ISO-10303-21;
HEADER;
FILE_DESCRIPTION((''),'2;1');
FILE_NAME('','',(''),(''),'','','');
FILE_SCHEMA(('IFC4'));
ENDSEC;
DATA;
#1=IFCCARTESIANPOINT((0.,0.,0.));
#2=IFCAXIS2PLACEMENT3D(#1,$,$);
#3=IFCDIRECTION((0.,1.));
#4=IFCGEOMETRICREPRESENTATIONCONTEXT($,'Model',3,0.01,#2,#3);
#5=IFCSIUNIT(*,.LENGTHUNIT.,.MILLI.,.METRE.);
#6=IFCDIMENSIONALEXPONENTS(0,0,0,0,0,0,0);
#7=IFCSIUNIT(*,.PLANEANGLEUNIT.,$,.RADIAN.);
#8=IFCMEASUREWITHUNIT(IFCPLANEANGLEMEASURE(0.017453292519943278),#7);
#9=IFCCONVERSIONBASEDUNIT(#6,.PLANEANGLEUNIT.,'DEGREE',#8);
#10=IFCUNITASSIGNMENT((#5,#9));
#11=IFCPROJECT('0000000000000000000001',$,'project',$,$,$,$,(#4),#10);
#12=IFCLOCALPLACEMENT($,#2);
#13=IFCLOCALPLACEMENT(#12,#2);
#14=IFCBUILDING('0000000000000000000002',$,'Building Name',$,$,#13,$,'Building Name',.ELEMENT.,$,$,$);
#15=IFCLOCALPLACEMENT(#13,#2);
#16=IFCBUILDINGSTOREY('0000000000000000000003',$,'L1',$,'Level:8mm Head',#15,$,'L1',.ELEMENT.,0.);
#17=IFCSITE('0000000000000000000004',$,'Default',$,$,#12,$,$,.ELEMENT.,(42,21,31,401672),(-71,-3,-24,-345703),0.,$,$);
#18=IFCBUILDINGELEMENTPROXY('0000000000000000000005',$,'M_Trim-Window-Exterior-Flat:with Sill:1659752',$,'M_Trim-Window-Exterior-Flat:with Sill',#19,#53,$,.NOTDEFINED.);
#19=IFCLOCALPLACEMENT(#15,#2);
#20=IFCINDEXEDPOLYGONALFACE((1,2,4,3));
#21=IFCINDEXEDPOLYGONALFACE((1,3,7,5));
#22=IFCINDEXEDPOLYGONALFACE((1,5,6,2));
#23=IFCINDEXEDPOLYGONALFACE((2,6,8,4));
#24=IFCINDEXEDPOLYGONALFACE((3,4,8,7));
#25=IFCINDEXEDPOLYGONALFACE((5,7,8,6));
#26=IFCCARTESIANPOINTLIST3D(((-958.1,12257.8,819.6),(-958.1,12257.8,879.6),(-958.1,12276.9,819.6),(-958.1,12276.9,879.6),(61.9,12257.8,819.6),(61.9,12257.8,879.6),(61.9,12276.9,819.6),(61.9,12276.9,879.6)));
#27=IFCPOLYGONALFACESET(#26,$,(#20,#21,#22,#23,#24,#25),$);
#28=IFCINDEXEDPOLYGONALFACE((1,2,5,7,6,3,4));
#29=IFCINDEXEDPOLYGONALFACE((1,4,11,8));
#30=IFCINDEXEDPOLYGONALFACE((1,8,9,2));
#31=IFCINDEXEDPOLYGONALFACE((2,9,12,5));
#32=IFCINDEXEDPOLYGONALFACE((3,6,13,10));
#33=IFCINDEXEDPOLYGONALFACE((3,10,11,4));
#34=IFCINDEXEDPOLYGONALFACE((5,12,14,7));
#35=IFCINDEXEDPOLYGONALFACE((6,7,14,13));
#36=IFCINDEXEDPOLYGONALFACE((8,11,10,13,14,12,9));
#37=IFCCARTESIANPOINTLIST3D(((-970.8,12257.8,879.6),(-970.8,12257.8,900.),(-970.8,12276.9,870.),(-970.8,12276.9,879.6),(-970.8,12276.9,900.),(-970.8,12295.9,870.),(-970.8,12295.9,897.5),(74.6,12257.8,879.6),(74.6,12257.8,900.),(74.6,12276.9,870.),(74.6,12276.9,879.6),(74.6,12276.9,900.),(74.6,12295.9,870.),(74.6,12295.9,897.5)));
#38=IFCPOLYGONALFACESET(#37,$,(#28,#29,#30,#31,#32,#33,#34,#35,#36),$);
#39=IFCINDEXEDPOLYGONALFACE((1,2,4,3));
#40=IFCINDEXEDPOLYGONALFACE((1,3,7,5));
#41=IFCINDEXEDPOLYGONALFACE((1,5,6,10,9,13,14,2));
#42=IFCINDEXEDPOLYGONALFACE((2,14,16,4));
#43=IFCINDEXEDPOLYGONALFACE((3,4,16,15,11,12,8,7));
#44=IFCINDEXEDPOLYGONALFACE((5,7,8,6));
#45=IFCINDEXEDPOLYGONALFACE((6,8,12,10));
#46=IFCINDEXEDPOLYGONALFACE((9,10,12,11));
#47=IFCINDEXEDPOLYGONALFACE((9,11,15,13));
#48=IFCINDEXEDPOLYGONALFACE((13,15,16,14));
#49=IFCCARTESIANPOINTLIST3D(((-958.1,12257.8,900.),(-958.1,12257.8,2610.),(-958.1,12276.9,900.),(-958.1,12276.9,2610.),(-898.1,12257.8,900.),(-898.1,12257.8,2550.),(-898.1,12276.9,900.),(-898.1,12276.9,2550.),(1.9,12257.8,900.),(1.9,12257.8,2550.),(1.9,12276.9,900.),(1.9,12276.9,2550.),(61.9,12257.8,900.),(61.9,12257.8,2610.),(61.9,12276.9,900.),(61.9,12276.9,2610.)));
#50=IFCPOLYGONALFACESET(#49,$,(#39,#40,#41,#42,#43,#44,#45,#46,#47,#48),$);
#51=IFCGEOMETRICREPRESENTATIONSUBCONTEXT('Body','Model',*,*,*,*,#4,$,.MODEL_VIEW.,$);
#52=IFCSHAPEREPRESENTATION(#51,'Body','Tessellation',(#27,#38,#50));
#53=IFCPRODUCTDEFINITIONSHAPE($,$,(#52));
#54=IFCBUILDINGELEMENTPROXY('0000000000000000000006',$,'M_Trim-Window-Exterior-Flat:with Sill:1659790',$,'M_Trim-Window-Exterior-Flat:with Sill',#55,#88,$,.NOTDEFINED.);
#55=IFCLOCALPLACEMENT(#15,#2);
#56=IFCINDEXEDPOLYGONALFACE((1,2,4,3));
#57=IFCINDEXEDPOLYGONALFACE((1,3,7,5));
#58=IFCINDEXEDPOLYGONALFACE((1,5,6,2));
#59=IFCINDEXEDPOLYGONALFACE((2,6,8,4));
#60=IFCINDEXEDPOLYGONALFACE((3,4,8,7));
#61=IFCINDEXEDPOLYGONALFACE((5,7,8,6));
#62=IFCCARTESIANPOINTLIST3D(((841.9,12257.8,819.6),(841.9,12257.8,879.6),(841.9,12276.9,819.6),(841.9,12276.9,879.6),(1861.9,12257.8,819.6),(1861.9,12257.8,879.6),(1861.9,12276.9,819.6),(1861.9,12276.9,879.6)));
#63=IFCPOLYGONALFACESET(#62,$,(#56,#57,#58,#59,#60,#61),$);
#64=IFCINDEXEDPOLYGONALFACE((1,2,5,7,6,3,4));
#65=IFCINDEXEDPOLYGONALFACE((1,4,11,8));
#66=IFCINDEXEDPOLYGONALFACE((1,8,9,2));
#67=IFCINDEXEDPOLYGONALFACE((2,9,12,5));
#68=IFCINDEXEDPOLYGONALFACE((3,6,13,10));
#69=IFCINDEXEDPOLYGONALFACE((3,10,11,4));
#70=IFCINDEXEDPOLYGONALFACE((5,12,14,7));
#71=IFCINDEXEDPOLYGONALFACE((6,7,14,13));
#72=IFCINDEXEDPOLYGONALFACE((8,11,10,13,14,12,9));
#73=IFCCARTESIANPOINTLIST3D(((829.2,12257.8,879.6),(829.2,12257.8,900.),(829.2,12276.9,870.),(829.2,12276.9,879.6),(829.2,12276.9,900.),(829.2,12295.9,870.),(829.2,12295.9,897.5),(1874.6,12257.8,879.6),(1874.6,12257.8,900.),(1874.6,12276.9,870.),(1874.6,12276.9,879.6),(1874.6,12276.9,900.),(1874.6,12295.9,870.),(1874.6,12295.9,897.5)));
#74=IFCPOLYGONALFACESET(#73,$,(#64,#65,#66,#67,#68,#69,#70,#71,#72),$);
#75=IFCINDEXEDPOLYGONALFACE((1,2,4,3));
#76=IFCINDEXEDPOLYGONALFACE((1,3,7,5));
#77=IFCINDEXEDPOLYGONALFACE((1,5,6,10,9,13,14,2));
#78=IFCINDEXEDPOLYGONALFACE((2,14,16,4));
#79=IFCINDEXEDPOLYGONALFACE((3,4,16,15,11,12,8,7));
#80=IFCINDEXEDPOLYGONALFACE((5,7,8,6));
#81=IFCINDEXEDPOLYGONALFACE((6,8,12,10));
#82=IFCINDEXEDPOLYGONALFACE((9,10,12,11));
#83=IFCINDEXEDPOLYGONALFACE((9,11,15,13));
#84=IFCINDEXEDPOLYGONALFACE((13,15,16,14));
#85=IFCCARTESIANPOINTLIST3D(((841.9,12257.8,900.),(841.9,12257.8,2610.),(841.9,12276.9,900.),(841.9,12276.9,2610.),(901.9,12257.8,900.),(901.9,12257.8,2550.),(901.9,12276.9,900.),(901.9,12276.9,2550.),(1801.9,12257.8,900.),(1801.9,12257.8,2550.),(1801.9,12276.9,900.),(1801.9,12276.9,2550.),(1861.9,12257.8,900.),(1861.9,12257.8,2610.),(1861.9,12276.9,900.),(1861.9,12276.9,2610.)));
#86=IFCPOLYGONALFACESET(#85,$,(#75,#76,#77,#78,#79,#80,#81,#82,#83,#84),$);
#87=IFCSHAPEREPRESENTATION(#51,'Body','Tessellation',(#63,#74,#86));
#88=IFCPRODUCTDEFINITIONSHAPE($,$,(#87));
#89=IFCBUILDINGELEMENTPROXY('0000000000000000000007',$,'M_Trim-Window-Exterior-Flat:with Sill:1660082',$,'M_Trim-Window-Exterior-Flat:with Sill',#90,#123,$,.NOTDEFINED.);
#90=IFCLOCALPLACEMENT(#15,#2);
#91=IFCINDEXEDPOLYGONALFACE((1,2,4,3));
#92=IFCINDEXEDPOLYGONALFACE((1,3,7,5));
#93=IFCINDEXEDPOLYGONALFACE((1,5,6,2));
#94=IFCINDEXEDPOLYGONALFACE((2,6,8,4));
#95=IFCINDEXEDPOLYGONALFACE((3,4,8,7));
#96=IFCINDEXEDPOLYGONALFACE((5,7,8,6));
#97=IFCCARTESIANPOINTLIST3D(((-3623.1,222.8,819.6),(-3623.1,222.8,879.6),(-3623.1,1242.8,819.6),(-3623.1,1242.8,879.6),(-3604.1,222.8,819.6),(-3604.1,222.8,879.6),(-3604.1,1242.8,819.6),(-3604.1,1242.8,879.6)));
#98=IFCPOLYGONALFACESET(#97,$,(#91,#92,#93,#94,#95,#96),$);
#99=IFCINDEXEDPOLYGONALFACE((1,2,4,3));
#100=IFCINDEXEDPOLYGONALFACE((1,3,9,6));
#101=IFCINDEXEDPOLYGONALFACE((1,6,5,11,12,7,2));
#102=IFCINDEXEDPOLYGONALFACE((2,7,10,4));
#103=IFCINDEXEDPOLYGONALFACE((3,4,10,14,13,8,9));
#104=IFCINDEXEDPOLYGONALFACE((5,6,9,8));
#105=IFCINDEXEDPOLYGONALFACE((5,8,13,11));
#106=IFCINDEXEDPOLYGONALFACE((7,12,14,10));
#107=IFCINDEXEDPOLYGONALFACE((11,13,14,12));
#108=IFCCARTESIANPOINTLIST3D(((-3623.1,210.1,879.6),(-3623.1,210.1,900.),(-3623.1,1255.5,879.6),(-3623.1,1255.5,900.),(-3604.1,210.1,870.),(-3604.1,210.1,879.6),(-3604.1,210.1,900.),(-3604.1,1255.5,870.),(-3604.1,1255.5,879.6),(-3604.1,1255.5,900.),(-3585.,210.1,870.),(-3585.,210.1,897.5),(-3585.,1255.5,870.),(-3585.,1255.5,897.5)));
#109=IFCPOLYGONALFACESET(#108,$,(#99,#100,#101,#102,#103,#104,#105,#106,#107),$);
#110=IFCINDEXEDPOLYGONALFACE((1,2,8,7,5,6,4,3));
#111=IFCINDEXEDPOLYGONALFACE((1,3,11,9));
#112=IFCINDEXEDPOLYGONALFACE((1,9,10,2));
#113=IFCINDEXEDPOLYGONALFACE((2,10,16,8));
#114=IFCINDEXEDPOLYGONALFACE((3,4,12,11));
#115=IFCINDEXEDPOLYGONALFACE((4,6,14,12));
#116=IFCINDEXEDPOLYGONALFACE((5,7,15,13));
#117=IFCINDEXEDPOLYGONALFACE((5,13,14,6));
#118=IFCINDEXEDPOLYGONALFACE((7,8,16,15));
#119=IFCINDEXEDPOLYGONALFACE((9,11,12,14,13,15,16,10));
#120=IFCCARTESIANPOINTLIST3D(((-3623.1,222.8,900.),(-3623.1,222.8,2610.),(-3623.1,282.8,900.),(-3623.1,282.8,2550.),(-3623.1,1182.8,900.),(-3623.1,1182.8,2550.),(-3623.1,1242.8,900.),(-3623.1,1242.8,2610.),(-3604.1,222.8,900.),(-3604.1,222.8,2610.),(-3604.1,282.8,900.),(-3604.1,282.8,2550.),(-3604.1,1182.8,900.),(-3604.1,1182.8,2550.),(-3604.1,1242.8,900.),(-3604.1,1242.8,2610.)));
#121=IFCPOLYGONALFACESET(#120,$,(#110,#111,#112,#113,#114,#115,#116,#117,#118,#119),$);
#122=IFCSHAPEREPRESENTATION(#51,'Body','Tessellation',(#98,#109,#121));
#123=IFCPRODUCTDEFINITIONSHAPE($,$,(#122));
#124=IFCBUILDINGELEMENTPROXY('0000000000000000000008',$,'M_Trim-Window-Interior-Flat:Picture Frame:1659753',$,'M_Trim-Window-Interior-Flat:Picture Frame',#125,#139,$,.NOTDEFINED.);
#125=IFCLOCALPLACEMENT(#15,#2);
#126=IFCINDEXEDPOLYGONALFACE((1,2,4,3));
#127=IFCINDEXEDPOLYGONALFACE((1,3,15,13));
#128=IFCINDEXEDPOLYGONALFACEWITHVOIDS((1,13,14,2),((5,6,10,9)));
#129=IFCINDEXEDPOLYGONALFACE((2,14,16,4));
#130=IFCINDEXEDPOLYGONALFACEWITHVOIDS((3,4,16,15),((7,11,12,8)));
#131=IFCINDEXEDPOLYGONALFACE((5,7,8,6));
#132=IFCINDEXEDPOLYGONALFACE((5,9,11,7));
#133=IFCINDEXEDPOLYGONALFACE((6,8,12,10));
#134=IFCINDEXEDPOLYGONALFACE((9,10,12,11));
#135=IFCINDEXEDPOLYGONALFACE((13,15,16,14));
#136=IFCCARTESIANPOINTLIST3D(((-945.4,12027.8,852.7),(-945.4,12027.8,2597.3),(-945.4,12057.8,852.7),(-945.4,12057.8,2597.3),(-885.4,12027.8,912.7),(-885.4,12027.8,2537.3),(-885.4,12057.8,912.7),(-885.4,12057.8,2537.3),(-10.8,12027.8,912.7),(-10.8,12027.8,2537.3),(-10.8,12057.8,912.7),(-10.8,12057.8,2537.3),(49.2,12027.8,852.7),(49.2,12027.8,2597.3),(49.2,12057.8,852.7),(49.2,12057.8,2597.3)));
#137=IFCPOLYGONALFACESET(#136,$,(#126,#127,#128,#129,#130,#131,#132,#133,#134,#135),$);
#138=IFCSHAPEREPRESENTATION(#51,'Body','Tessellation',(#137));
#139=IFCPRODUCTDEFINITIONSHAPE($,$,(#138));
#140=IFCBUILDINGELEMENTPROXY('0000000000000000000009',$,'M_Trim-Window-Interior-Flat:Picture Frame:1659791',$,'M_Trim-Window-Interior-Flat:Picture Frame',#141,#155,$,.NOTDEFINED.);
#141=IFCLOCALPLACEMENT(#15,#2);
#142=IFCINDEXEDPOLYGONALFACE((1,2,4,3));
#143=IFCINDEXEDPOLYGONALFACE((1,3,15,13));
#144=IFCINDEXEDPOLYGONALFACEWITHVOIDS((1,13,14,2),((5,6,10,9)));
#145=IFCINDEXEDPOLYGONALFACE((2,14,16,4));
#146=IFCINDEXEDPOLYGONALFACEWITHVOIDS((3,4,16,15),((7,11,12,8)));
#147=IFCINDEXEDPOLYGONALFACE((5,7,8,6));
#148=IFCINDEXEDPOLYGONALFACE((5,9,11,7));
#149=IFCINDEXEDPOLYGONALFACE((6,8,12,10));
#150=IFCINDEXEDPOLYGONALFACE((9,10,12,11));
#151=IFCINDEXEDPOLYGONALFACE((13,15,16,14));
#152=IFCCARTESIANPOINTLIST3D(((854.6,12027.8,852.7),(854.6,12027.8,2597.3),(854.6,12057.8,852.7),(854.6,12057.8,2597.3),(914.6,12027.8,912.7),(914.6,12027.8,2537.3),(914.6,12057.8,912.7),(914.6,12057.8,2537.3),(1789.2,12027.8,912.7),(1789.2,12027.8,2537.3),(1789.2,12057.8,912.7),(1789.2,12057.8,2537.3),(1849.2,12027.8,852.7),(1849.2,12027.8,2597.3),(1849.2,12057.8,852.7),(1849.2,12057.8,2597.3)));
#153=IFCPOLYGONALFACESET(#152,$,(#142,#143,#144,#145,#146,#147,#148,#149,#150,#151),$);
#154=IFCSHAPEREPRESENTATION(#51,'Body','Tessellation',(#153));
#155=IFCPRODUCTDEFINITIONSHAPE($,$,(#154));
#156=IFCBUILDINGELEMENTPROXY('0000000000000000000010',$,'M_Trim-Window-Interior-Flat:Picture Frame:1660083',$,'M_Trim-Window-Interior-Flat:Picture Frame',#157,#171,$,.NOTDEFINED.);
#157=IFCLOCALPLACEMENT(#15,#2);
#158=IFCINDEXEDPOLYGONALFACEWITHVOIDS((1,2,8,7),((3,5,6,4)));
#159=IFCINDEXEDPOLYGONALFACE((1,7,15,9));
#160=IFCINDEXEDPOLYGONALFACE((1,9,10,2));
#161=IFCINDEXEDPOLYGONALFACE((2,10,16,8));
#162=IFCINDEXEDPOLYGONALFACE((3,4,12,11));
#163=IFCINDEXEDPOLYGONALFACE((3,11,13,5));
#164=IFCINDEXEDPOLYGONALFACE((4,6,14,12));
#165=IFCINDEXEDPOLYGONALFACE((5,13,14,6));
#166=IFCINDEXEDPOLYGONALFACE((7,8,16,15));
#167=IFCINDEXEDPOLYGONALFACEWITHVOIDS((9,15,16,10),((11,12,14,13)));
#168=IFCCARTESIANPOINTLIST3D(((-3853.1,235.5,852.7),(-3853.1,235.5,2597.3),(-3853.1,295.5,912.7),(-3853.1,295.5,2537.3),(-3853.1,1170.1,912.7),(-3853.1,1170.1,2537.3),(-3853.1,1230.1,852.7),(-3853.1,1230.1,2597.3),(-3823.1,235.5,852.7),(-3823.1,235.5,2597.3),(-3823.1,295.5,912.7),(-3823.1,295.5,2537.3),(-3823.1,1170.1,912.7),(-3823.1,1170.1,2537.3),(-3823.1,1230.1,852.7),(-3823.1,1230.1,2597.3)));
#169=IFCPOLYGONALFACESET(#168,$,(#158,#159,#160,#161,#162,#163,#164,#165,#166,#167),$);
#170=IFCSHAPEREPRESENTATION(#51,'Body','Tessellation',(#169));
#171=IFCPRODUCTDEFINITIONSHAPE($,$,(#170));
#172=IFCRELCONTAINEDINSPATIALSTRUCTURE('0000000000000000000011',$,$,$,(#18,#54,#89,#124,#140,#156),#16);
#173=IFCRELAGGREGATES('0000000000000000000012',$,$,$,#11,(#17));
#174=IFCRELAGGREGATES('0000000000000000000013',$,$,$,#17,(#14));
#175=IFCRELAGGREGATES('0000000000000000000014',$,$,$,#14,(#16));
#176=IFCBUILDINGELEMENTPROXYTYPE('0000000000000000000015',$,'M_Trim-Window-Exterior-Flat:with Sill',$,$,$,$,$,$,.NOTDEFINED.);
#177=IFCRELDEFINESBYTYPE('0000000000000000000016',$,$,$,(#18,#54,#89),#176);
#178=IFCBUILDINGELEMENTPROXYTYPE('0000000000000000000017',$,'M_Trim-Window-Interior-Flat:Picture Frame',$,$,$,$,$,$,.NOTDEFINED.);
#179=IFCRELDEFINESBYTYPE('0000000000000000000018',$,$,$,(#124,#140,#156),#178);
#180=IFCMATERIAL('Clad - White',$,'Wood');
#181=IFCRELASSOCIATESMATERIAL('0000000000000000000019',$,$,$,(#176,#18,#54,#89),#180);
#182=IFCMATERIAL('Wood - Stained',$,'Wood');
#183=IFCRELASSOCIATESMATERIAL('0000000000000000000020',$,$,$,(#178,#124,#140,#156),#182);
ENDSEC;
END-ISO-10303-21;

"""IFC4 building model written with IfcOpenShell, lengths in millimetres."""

from ifc_helpers import new_model, entity, si_unit, converted_unit, direction, frame, origin, place, context, subcontext, project, spatial, indexed_curve, outline, extrude, source, transform, mapped, material, type_object, type_shapes, element, save


model = new_model("IFC4")

# Units and contexts
model_context = context("Model", 3, precision=0.01, world=origin(), true_north=direction((0.0, 1.0)))
body_context = subcontext(model_context, "Body", "Model", "MODEL_VIEW")
ifc_project = project(units=[si_unit("LENGTHUNIT", "METRE", prefix="MILLI"), converted_unit("PLANEANGLEUNIT", "DEGREE", entity("IfcPlaneAngleMeasure", 0.017453292519943278), si_unit("PLANEANGLEUNIT", "RADIAN"), dimensions=[0, 0, 0, 0, 0, 0, 0])], contexts=[model_context])

# Site, building, storey
site_placement = place(None, origin())
site = spatial("IfcSite", under=ifc_project, at=site_placement, Name="Default", CompositionType="ELEMENT", RefLatitude=(42, 21, 31, 401672), RefLongitude=(-71, -3, -24, -345703), RefElevation=0.0)
building_placement = place(site_placement, origin())
building = spatial("IfcBuilding", under=site, at=building_placement, Name="Building Name", LongName="Building Name", CompositionType="ELEMENT")
storey_placement = place(building_placement, origin())
storey = spatial("IfcBuildingStorey", under=building, at=storey_placement, Name="L1", ObjectType="Level:8mm Head", LongName="L1", CompositionType="ELEMENT", Elevation=0.0)

# Building element proxies
ifc_material_1 = material(Name="Clad - White", Category="Wood")
ifc_material_2 = material(Name="Wood - Stained", Category="Wood")
building_element_proxy_type_1 = type_object("IfcBuildingElementProxyType", Name="M_Trim-Window-Exterior-Flat:with Sill", PredefinedType="NOTDEFINED", material=ifc_material_1)
shared_shape_1 = source(origin(), body_context, "Body", "SweptSolid", [
    extrude(outline(indexed_curve([(-510.0, -30.0), (510.0, -30.0), (510.0, 30.0), (-510.0, 30.0), (-510.0, -30.0)], self_intersect=False)), frame((0.0, -1700.4, 0.0), z_axis=(0.0, 0.0, 1.0), x_axis=(-1.0, 0.0, 0.0)), (0.0, 0.0, 1.0), 19.0),
    extrude(outline(indexed_curve([(-19.0, -15.2), (0.0, -15.2), (0.0, -5.7), (19.0, -5.7), (19.0, 14.8), (0.0, 14.8), (-19.0, 12.3), (-19.0, -15.2)], self_intersect=False)), frame((-522.7, -1664.8, 19.0), z_axis=(1.0, 0.0, 0.0), x_axis=(0.0, 0.0, -1.0)), (0.0, 0.0, 1.0), 1045.4),
    extrude(outline(indexed_curve([(-870.0, -510.0), (840.0, -510.0), (840.0, -450.0), (-810.0, -450.0), (-810.0, 450.0), (840.0, 450.0), (840.0, 510.0), (-870.0, 510.0), (-870.0, -510.0)], self_intersect=False)), frame((0.0, -810.0, 0.0), z_axis=(0.0, 0.0, 1.0), x_axis=(0.0, -1.0, 0.0)), (0.0, 0.0, 1.0), 19.0),
])
type_shapes(building_element_proxy_type_1, [shared_shape_1])
for number, where, z_axis, x_axis, name in (
    (1, (-448.1, 12257.8, 2550.0), (0.0, 1.0, 0.0), (-1.0, 0.0, 0.0), "M_Trim-Window-Exterior-Flat:with Sill:1659752"),
    (2, (1351.9, 12257.8, 2550.0), (0.0, 1.0, 0.0), (-1.0, 0.0, 0.0), "M_Trim-Window-Exterior-Flat:with Sill:1659790"),
    (3, (-3623.1, 732.8, 2550.0), (1.0, 0.0, 0.0), (0.0, 1.0, 0.0), "M_Trim-Window-Exterior-Flat:with Sill:1660082"),
):
    element("IfcBuildingElementProxy", number, at=place(storey_placement, frame(where, z_axis=z_axis, x_axis=x_axis)), inside=storey, type_object=building_element_proxy_type_1, material=ifc_material_1, Name=name, ObjectType="M_Trim-Window-Exterior-Flat:with Sill", PredefinedType="NOTDEFINED", context=body_context, shape_type="MappedRepresentation", body=[
        mapped(shared_shape_1, transform((0.0, 0.0, 0.0), scale=1.0)),
    ])
building_element_proxy_type_2 = type_object("IfcBuildingElementProxyType", Name="M_Trim-Window-Interior-Flat:Picture Frame", PredefinedType="NOTDEFINED", material=ifc_material_2)
shared_shape_2 = source(origin(), body_context, "Body", "SweptSolid", [
    extrude(outline(indexed_curve([(-497.3, -872.3), (497.3, -872.3), (497.3, 872.3), (-497.3, 872.3), (-497.3, -872.3)], self_intersect=False), holes=[indexed_curve([(-437.3, -812.3), (-437.3, 812.3), (437.3, 812.3), (437.3, -812.3), (-437.3, -812.3)], self_intersect=False)]), frame((0.0, -825.0, 0.0), z_axis=(0.0, 0.0, 1.0), x_axis=(-1.0, 0.0, 0.0)), (0.0, 0.0, 1.0), 30.0),
])
type_shapes(building_element_proxy_type_2, [shared_shape_2])
for number, where, z_axis, x_axis, name in (
    (4, (-448.1, 12057.8, 2550.0), (0.0, -1.0, 0.0), (1.0, 0.0, 0.0), "M_Trim-Window-Interior-Flat:Picture Frame:1659753"),
    (5, (1351.9, 12057.8, 2550.0), (0.0, -1.0, 0.0), (1.0, 0.0, 0.0), "M_Trim-Window-Interior-Flat:Picture Frame:1659791"),
    (6, (-3823.1, 732.8, 2550.0), (-1.0, 0.0, 0.0), (0.0, -1.0, 0.0), "M_Trim-Window-Interior-Flat:Picture Frame:1660083"),
):
    element("IfcBuildingElementProxy", number, at=place(storey_placement, frame(where, z_axis=z_axis, x_axis=x_axis)), inside=storey, type_object=building_element_proxy_type_2, material=ifc_material_2, Name=name, ObjectType="M_Trim-Window-Interior-Flat:Picture Frame", PredefinedType="NOTDEFINED", context=body_context, shape_type="MappedRepresentation", body=[
        mapped(shared_shape_2, transform((0.0, 0.0, 0.0), scale=1.0)),
    ])

save(model, "model.ifc")
